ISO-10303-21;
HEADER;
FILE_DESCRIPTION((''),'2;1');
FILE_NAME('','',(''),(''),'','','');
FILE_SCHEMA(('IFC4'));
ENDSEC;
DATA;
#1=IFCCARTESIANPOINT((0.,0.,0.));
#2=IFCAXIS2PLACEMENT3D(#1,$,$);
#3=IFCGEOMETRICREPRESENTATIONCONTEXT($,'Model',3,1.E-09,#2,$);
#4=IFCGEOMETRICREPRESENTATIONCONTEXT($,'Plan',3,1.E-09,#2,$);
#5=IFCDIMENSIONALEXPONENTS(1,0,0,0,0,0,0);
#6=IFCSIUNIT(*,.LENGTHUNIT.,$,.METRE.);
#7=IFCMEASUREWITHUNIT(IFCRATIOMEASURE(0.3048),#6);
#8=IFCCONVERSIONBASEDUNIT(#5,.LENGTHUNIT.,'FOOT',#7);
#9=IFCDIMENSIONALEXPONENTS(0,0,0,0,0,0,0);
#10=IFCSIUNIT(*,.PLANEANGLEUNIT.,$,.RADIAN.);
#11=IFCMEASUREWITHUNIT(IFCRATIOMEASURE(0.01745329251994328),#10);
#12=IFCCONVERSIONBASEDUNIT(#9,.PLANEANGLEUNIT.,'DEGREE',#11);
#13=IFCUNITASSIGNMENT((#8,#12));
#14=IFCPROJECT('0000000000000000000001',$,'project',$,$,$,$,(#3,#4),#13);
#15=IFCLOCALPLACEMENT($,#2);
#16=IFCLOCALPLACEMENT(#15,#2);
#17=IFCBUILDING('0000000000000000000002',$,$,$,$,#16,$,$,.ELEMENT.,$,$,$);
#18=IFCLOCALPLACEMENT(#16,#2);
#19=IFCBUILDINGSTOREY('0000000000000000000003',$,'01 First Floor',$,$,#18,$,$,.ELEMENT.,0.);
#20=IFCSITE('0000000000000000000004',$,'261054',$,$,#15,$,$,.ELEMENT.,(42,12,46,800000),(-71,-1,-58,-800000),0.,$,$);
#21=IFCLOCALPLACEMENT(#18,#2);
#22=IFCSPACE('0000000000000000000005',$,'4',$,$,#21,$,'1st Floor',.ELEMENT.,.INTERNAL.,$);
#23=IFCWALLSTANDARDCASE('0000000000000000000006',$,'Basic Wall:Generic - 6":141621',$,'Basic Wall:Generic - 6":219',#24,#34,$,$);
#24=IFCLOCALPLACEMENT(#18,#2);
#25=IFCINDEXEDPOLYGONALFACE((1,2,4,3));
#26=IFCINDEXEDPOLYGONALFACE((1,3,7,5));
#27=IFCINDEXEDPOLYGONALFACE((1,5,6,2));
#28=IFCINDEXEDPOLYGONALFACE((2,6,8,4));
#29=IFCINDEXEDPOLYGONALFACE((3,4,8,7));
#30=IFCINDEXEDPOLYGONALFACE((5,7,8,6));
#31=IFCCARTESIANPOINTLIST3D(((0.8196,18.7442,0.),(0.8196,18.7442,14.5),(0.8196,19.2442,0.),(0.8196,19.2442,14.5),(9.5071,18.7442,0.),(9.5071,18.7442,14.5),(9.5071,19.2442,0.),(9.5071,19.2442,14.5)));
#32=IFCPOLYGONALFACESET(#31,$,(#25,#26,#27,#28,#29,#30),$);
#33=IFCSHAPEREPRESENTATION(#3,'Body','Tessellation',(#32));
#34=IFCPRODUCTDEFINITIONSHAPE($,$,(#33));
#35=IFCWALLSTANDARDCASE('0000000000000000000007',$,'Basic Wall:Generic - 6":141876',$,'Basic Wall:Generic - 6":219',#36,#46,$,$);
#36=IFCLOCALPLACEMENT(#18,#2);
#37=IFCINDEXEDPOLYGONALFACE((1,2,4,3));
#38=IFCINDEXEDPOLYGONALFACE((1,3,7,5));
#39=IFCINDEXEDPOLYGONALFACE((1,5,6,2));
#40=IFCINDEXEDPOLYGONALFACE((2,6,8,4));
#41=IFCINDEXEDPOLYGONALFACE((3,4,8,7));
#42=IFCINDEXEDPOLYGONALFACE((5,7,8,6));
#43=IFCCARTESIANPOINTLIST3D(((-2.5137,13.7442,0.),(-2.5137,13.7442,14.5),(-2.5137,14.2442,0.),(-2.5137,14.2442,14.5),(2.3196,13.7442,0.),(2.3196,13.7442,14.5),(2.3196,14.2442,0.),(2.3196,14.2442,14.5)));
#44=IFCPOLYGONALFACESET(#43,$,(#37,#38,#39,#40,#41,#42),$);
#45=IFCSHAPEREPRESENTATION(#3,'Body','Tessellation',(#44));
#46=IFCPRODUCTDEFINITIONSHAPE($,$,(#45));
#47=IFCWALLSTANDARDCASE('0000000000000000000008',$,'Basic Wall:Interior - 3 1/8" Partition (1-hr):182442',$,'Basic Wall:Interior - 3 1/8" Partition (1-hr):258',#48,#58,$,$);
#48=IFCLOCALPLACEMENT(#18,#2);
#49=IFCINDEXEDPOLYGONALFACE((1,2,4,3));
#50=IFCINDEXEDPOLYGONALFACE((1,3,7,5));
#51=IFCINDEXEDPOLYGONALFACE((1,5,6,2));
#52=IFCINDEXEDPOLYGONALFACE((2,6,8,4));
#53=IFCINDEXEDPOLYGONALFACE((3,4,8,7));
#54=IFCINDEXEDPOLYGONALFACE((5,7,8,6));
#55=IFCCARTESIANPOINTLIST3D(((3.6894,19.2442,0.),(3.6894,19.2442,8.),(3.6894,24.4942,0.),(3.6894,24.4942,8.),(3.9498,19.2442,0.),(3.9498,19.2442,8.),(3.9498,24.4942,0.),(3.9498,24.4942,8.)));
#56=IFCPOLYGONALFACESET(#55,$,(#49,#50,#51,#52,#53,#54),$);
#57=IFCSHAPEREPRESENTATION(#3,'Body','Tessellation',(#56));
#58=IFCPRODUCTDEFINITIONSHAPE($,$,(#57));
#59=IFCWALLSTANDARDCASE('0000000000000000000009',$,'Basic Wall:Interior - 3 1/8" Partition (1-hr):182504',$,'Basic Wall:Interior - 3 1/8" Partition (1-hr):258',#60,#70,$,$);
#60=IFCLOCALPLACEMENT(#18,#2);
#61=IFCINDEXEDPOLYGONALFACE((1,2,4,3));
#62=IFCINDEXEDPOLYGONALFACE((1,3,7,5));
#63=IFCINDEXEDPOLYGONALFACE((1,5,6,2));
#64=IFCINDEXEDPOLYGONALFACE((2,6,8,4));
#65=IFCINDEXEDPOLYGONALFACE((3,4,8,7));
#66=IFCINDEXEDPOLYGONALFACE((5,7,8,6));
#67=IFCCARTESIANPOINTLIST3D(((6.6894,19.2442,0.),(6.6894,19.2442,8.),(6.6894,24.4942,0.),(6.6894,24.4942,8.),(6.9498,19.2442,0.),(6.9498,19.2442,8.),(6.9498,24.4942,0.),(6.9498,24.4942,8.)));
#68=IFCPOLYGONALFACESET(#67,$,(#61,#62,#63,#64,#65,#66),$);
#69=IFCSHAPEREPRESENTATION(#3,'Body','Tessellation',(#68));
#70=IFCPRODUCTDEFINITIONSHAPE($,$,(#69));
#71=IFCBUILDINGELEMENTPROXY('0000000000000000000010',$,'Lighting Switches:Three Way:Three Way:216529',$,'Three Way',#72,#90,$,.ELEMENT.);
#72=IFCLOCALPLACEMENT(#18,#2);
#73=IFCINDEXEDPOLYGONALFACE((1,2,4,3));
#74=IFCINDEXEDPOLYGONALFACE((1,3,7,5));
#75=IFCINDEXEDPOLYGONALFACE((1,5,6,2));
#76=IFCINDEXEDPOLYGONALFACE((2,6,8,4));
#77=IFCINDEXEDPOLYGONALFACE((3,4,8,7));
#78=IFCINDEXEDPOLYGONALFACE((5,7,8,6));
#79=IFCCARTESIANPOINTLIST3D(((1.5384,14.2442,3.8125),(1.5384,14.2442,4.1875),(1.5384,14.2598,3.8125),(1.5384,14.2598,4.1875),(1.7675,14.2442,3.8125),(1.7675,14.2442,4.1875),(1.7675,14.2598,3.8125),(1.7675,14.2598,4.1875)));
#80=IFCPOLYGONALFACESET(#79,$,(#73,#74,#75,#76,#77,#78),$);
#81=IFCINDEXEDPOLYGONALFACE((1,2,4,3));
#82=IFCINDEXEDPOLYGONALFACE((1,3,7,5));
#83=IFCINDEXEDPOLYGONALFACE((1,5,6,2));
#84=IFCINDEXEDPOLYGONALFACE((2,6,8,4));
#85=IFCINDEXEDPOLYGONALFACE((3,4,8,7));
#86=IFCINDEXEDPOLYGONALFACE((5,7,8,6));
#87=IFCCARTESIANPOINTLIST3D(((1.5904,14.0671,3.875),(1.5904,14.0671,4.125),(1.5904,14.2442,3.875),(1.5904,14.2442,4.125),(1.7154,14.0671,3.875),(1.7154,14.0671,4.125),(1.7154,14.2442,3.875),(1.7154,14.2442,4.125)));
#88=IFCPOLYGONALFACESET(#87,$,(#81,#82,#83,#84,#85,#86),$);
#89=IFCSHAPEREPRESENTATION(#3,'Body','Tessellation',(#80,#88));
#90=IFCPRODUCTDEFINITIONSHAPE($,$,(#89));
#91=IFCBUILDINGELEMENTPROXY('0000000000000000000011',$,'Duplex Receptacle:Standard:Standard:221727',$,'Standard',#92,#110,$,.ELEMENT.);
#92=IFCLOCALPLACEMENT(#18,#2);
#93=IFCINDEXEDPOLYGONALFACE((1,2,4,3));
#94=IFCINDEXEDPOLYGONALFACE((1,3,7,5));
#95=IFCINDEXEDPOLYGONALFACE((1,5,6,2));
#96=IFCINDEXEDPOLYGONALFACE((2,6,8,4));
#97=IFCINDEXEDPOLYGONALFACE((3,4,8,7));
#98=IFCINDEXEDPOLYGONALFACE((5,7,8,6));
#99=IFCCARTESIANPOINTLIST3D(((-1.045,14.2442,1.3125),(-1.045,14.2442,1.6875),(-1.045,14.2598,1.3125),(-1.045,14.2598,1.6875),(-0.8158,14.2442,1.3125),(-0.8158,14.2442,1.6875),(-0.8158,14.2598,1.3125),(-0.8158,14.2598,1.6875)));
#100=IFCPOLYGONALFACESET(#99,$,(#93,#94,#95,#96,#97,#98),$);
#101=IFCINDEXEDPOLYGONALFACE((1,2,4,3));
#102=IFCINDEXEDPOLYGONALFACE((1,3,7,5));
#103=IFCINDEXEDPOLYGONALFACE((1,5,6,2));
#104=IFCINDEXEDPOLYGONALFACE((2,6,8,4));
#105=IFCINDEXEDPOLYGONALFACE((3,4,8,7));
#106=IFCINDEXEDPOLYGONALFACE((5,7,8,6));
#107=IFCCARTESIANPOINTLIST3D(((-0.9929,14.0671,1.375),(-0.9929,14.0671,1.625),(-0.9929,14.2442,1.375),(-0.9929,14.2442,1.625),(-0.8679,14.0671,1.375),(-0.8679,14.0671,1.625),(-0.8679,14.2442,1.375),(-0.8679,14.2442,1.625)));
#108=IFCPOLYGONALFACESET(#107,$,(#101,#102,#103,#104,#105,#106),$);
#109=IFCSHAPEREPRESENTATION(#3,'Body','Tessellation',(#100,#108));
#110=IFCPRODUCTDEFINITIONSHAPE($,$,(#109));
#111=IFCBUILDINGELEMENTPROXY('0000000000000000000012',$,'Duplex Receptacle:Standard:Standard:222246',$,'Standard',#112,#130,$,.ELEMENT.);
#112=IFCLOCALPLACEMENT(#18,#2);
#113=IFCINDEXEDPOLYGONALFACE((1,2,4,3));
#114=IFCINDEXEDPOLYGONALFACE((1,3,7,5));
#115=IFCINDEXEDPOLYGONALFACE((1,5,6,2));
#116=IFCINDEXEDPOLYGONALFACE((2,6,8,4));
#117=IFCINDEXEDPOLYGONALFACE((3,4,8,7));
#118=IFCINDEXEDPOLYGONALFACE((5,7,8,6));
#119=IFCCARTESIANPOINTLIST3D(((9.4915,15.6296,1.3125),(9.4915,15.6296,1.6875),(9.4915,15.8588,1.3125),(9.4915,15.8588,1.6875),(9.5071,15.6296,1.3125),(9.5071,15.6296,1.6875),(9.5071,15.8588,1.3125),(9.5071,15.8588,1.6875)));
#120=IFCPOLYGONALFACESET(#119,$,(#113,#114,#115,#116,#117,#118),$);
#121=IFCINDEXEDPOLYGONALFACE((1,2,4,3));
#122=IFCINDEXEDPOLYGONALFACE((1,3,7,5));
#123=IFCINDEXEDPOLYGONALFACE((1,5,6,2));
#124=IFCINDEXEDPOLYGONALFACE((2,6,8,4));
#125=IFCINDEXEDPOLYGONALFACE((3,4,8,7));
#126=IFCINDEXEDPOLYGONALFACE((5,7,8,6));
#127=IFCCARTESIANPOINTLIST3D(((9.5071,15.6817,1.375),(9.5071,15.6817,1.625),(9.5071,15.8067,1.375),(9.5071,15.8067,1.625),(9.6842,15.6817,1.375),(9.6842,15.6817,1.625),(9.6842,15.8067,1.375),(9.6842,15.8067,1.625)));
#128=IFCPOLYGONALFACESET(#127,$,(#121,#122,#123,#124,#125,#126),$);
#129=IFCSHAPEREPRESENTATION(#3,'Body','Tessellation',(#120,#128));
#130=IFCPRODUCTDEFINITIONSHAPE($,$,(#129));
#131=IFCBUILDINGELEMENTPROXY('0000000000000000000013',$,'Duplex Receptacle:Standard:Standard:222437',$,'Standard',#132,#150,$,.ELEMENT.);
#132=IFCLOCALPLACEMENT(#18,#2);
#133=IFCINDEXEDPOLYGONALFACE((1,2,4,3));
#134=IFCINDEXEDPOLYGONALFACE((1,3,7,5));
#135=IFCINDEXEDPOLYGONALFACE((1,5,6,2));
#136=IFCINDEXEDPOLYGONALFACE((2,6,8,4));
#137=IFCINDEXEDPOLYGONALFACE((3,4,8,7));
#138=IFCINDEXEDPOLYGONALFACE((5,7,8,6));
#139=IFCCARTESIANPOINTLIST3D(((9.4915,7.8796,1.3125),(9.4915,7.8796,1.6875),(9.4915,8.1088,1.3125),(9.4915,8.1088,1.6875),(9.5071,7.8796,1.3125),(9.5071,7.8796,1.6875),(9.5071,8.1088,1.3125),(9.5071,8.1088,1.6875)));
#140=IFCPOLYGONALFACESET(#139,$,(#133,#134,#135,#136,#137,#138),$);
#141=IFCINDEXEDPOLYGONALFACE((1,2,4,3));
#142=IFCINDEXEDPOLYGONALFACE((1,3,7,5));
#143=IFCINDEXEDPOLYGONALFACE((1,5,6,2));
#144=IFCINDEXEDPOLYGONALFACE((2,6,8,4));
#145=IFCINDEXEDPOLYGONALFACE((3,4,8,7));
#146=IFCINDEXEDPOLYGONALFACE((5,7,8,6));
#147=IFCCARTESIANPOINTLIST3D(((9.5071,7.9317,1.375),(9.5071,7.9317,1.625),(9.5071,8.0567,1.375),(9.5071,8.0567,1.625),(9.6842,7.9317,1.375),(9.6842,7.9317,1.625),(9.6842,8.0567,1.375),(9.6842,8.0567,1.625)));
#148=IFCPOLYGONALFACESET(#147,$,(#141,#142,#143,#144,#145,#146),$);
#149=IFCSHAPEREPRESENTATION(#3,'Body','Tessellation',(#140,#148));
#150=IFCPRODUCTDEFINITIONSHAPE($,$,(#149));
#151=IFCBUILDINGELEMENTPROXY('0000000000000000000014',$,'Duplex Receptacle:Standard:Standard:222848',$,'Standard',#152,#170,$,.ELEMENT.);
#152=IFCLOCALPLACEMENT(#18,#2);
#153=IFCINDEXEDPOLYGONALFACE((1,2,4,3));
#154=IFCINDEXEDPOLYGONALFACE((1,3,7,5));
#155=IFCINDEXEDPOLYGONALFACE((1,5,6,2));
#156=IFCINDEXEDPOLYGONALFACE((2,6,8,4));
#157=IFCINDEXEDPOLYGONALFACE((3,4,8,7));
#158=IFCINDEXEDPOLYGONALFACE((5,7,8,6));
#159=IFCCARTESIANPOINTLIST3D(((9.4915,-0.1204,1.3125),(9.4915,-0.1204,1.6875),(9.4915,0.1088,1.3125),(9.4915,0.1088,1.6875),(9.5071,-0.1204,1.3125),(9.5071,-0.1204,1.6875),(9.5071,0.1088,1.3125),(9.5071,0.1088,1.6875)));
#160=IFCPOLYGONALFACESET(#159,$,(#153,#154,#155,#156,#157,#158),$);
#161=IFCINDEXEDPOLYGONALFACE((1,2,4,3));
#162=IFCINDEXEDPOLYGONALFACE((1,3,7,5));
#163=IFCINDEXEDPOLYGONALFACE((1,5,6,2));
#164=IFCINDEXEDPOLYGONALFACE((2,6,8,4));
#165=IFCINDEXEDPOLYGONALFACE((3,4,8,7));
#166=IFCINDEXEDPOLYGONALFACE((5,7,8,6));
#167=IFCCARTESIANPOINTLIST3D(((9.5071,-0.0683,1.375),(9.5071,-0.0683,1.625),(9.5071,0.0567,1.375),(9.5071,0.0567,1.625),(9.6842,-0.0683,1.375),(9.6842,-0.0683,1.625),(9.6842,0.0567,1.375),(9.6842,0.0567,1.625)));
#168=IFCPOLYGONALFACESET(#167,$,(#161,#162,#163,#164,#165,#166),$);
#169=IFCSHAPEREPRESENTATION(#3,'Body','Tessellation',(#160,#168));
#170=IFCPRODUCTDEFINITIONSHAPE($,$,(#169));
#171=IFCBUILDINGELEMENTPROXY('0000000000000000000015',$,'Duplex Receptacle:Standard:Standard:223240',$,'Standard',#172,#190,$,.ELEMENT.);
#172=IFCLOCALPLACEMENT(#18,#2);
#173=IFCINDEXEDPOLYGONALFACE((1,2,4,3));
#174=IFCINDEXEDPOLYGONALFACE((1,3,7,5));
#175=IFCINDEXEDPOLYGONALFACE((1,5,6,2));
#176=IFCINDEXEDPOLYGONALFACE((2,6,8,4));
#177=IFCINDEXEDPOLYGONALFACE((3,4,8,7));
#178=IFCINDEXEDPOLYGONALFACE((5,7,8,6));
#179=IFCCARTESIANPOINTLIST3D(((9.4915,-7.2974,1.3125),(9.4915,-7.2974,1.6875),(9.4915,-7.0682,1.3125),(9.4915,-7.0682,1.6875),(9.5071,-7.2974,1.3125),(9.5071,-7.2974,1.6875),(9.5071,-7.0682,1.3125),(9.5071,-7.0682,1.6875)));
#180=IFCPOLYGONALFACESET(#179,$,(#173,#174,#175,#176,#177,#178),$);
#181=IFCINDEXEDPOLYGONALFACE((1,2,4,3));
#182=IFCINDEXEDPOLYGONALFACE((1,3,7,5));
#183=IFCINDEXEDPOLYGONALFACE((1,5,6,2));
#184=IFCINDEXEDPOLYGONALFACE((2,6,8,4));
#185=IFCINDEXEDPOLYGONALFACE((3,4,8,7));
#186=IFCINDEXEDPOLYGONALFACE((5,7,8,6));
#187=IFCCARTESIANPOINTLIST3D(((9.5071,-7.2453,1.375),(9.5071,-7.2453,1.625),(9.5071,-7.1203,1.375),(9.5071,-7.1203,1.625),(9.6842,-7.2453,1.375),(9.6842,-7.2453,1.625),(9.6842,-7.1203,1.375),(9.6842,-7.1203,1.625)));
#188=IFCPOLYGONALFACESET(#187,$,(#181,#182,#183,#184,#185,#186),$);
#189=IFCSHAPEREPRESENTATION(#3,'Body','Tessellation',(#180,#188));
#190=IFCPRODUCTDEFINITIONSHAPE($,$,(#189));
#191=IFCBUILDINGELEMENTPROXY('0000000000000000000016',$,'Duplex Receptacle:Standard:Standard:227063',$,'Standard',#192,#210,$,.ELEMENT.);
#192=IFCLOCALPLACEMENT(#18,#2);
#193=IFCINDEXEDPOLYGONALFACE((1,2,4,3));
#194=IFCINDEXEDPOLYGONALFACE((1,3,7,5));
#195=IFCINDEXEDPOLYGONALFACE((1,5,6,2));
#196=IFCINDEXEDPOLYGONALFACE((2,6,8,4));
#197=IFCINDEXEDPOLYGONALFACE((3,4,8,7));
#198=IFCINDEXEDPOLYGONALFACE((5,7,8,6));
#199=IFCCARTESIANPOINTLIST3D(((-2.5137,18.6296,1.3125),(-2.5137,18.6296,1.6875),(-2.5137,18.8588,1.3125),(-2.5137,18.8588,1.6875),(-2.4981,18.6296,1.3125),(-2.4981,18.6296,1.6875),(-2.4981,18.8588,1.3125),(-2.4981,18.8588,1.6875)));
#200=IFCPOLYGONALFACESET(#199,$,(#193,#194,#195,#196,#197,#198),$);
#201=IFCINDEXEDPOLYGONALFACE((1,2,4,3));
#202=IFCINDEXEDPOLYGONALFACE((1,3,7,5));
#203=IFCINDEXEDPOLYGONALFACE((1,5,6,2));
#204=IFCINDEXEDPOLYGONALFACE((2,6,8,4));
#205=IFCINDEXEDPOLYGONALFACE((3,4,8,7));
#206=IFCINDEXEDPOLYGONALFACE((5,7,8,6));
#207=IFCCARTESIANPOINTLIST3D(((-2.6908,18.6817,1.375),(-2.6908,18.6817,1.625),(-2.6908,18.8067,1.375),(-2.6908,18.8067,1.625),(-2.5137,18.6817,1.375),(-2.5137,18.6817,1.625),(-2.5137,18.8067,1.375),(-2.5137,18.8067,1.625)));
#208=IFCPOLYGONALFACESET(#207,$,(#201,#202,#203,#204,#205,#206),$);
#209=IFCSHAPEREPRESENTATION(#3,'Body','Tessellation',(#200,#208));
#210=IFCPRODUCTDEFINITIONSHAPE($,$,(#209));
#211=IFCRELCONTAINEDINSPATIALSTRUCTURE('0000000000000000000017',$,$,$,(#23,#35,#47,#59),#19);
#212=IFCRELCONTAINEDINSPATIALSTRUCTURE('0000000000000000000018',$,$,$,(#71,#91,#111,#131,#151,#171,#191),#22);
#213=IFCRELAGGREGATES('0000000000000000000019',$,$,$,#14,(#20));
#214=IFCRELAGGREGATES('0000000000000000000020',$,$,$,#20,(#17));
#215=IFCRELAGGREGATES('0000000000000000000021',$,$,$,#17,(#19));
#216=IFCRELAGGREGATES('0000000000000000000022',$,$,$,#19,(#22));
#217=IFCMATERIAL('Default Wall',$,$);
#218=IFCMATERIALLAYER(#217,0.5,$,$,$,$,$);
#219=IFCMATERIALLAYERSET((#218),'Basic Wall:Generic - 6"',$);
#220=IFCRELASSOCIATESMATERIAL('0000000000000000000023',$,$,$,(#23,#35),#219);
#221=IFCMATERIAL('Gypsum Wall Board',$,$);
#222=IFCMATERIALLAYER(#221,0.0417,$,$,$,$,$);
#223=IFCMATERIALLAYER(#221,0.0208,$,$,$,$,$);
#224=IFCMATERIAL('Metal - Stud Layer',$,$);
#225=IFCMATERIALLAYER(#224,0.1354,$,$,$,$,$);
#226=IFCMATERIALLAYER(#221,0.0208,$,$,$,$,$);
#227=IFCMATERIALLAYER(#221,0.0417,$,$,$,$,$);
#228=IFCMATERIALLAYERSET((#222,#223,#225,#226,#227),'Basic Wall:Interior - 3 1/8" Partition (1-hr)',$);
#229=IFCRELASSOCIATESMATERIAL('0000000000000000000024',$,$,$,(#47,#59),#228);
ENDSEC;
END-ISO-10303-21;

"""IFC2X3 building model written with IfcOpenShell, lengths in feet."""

from ifc_helpers import new_model, entity, si_unit, converted_unit, frame, frame_2d, origin, origin_2d_with_axis, place, context, project, spatial, polyline, rectangle, extrude, clip, bounded_halfspace, source, transform, mapped, material, layer, layer_set, layer_usage, element, save


model = new_model("IFC2X3")

# Units and contexts
model_context = context("Model", 3, precision=1e-09, world=origin())
plan_context = context("Plan", 3, precision=1e-09, world=origin())
ifc_project = project(units=[converted_unit("LENGTHUNIT", "FOOT", entity("IfcRatioMeasure", 0.3048), si_unit("LENGTHUNIT", "METRE"), dimensions=[1, 0, 0, 0, 0, 0, 0]), converted_unit("PLANEANGLEUNIT", "DEGREE", entity("IfcRatioMeasure", 0.01745329251994328), si_unit("PLANEANGLEUNIT", "RADIAN"), dimensions=[0, 0, 0, 0, 0, 0, 0])], contexts=[model_context, plan_context])

# Site, building, storey
site_placement = place(None, origin())
site = spatial("IfcSite", under=ifc_project, at=site_placement, Name="261054", CompositionType="ELEMENT", RefLatitude=(42, 12, 46, 800000), RefLongitude=(-71, -1, -58, -800000), RefElevation=0.0)
building_placement = place(site_placement, origin())
building = spatial("IfcBuilding", under=site, at=building_placement, CompositionType="ELEMENT")
storey_placement = place(building_placement, origin())
storey = spatial("IfcBuildingStorey", under=building, at=storey_placement, Name="01 First Floor", CompositionType="ELEMENT", Elevation=0.0)

# Walls
ifc_material_1 = material(Name="Default Wall")
ifc_layer_1 = layer(ifc_material_1, 0.5)
ifc_layer_set_1 = layer_set([ifc_layer_1], Name="Basic Wall:Generic - 6\"")
ifc_layer_usage_1 = layer_usage(ifc_layer_set_1, "AXIS2", "NEGATIVE", 0.25)
wall_1_placement = place(storey_placement, frame((0.8196, 18.9942, 0.0)))
element("IfcWallStandardCase", 1, at=wall_1_placement, inside=storey, material=ifc_layer_usage_1, Name="Basic Wall:Generic - 6\":141621", ObjectType="Basic Wall:Generic - 6\":219", context=model_context, shape_type="Clipping", body=[
    clip(extrude(rectangle(XDim=8.6875, YDim=0.5, at=frame_2d((4.3437, 0.0), x_axis=(-1.0, 0.0))), origin(), (0.0, 0.0, 1.0), 14.5), bounded_halfspace(frame((0.0, -0.25, 14.5), z_axis=(0.0, 0.0, -1.0), x_axis=(1.0, 0.0, 0.0)), True, frame((0.0, -0.25, 14.5)), polyline([(0.0, 0.0), (8.6875, 0.0), (8.6875, 0.5), (0.5, 0.5), (0.0, 0.5), (0.0, 0.0)]))),
])
ifc_layer_usage_2 = layer_usage(ifc_layer_set_1, "AXIS2", "NEGATIVE", 0.25)
wall_2_placement = place(storey_placement, frame((-2.5137, 13.9942, 0.0)))
element("IfcWallStandardCase", 2, at=wall_2_placement, inside=storey, material=ifc_layer_usage_2, Name="Basic Wall:Generic - 6\":141876", ObjectType="Basic Wall:Generic - 6\":219", context=model_context, shape_type="Clipping", body=[
    clip(extrude(rectangle(XDim=4.8333, YDim=0.5, at=frame_2d((2.4167, 0.0), x_axis=(-1.0, 0.0))), origin(), (0.0, 0.0, 1.0), 14.5), bounded_halfspace(frame((0.0, -0.25, 14.5), z_axis=(0.0, 0.0, -1.0), x_axis=(1.0, 0.0, 0.0)), True, frame((0.0, -0.25, 14.5)), polyline([(0.0, 0.0), (4.8333, 0.0), (4.8333, 0.5), (0.0, 0.5), (0.0, 0.0)]))),
])
ifc_material_2 = material(Name="Gypsum Wall Board")
ifc_layer_2 = layer(ifc_material_2, 0.0417)
ifc_layer_3 = layer(ifc_material_2, 0.0208)
ifc_material_3 = material(Name="Metal - Stud Layer")
ifc_layer_4 = layer(ifc_material_3, 0.1354)
ifc_layer_5 = layer(ifc_material_2, 0.0208)
ifc_layer_6 = layer(ifc_material_2, 0.0417)
ifc_layer_set_2 = layer_set([ifc_layer_2, ifc_layer_3, ifc_layer_4, ifc_layer_5, ifc_layer_6], Name="Basic Wall:Interior - 3 1/8\" Partition (1-hr)")
ifc_layer_usage_3 = layer_usage(ifc_layer_set_2, "AXIS2", "POSITIVE", -0.1302)
wall_3_placement = place(storey_placement, frame((3.8196, 19.2442, 0.0), z_axis=(0.0, 0.0, 1.0), x_axis=(0.0, 1.0, 0.0)))
element("IfcWallStandardCase", 3, at=wall_3_placement, inside=storey, material=ifc_layer_usage_3, Name="Basic Wall:Interior - 3 1/8\" Partition (1-hr):182442", ObjectType="Basic Wall:Interior - 3 1/8\" Partition (1-hr):258", context=model_context, shape_type="SweptSolid", body=[
    extrude(rectangle(XDim=5.25, YDim=0.2604, at=frame_2d((2.625, 0.0), x_axis=(-1.0, 0.0))), origin(), (0.0, 0.0, 1.0), 8.0),
])
ifc_layer_usage_4 = layer_usage(ifc_layer_set_2, "AXIS2", "NEGATIVE", 0.1302)
wall_4_placement = place(storey_placement, frame((6.8196, 19.2442, 0.0), z_axis=(0.0, 0.0, 1.0), x_axis=(0.0, 1.0, 0.0)))
element("IfcWallStandardCase", 4, at=wall_4_placement, inside=storey, material=ifc_layer_usage_4, Name="Basic Wall:Interior - 3 1/8\" Partition (1-hr):182504", ObjectType="Basic Wall:Interior - 3 1/8\" Partition (1-hr):258", context=model_context, shape_type="SweptSolid", body=[
    extrude(rectangle(XDim=5.25, YDim=0.2604, at=frame_2d((2.625, 0.0), x_axis=(-1.0, 0.0))), origin(), (0.0, 0.0, 1.0), 8.0),
])

# Shared definitions
space_placement = place(storey_placement, origin())
space = spatial("IfcSpace", under=storey, at=space_placement, Name="4", LongName="1st Floor", CompositionType="ELEMENT", InteriorOrExteriorSpace="INTERNAL")

# Building element proxies
shared_shape_1 = source(origin(), model_context, "Body", "SweptSolid", [
    extrude(rectangle(XDim=0.2292, YDim=0.375, at=origin_2d_with_axis()), frame((0.0, 0.0, 0.0), z_axis=(0.0, 0.0, 1.0), x_axis=(-1.0, 0.0, 0.0)), (0.0, 0.0, 1.0), 0.0156),
    extrude(rectangle(XDim=0.125, YDim=0.25, at=origin_2d_with_axis()), frame((0.0, 0.0, -0.1771), z_axis=(0.0, 0.0, 1.0), x_axis=(-1.0, 0.0, 0.0)), (0.0, 0.0, 1.0), 0.1771),
])
proxy_placement = place(space_placement, frame((1.6529, 14.2442, 4.0), z_axis=(0.0, 1.0, 0.0), x_axis=(-1.0, 0.0, 0.0)))
element("IfcBuildingElementProxy", 5, at=proxy_placement, inside=space, Name="Lighting Switches:Three Way:Three Way:216529", ObjectType="Three Way", CompositionType="ELEMENT", context=model_context, shape_type="MappedRepresentation", body=[
    mapped(shared_shape_1, transform((0.0, 0.0, 0.0), scale=1.0)),
])
shared_shape_2 = source(origin(), model_context, "Body", "SweptSolid", [
    extrude(rectangle(XDim=0.2292, YDim=0.375, at=origin_2d_with_axis()), frame((0.0, 0.0, 0.0), z_axis=(0.0, 0.0, 1.0), x_axis=(-1.0, 0.0, 0.0)), (0.0, 0.0, 1.0), 0.0156),
    extrude(rectangle(XDim=0.125, YDim=0.25, at=origin_2d_with_axis()), frame((0.0, 0.0, -0.1771), z_axis=(0.0, 0.0, 1.0), x_axis=(-1.0, 0.0, 0.0)), (0.0, 0.0, 1.0), 0.1771),
])
for number, where, z_axis, x_axis, name in (
    (6, (-0.9304, 14.2442, 1.5), (0.0, 1.0, 0.0), (-1.0, 0.0, 0.0), "Duplex Receptacle:Standard:Standard:221727"),
    (7, (9.5071, 15.7442, 1.5), (-1.0, 0.0, 0.0), (0.0, -1.0, 0.0), "Duplex Receptacle:Standard:Standard:222246"),
    (8, (9.5071, 7.9942, 1.5), (-1.0, 0.0, 0.0), (0.0, -1.0, 0.0), "Duplex Receptacle:Standard:Standard:222437"),
    (9, (9.5071, -0.0058, 1.5), (-1.0, 0.0, 0.0), (0.0, -1.0, 0.0), "Duplex Receptacle:Standard:Standard:222848"),
    (10, (9.5071, -7.1828, 1.5), (-1.0, 0.0, 0.0), (0.0, -1.0, 0.0), "Duplex Receptacle:Standard:Standard:223240"),
    (11, (-2.5137, 18.7442, 1.5), (1.0, 0.0, 0.0), (0.0, 1.0, 0.0), "Duplex Receptacle:Standard:Standard:227063"),
):
    element("IfcBuildingElementProxy", number, at=place(space_placement, frame(where, z_axis=z_axis, x_axis=x_axis)), inside=space, Name=name, ObjectType="Standard", CompositionType="ELEMENT", context=model_context, shape_type="MappedRepresentation", body=[
        mapped(shared_shape_2, transform((0.0, 0.0, 0.0), scale=1.0)),
    ])

save(model, "model.ifc")
